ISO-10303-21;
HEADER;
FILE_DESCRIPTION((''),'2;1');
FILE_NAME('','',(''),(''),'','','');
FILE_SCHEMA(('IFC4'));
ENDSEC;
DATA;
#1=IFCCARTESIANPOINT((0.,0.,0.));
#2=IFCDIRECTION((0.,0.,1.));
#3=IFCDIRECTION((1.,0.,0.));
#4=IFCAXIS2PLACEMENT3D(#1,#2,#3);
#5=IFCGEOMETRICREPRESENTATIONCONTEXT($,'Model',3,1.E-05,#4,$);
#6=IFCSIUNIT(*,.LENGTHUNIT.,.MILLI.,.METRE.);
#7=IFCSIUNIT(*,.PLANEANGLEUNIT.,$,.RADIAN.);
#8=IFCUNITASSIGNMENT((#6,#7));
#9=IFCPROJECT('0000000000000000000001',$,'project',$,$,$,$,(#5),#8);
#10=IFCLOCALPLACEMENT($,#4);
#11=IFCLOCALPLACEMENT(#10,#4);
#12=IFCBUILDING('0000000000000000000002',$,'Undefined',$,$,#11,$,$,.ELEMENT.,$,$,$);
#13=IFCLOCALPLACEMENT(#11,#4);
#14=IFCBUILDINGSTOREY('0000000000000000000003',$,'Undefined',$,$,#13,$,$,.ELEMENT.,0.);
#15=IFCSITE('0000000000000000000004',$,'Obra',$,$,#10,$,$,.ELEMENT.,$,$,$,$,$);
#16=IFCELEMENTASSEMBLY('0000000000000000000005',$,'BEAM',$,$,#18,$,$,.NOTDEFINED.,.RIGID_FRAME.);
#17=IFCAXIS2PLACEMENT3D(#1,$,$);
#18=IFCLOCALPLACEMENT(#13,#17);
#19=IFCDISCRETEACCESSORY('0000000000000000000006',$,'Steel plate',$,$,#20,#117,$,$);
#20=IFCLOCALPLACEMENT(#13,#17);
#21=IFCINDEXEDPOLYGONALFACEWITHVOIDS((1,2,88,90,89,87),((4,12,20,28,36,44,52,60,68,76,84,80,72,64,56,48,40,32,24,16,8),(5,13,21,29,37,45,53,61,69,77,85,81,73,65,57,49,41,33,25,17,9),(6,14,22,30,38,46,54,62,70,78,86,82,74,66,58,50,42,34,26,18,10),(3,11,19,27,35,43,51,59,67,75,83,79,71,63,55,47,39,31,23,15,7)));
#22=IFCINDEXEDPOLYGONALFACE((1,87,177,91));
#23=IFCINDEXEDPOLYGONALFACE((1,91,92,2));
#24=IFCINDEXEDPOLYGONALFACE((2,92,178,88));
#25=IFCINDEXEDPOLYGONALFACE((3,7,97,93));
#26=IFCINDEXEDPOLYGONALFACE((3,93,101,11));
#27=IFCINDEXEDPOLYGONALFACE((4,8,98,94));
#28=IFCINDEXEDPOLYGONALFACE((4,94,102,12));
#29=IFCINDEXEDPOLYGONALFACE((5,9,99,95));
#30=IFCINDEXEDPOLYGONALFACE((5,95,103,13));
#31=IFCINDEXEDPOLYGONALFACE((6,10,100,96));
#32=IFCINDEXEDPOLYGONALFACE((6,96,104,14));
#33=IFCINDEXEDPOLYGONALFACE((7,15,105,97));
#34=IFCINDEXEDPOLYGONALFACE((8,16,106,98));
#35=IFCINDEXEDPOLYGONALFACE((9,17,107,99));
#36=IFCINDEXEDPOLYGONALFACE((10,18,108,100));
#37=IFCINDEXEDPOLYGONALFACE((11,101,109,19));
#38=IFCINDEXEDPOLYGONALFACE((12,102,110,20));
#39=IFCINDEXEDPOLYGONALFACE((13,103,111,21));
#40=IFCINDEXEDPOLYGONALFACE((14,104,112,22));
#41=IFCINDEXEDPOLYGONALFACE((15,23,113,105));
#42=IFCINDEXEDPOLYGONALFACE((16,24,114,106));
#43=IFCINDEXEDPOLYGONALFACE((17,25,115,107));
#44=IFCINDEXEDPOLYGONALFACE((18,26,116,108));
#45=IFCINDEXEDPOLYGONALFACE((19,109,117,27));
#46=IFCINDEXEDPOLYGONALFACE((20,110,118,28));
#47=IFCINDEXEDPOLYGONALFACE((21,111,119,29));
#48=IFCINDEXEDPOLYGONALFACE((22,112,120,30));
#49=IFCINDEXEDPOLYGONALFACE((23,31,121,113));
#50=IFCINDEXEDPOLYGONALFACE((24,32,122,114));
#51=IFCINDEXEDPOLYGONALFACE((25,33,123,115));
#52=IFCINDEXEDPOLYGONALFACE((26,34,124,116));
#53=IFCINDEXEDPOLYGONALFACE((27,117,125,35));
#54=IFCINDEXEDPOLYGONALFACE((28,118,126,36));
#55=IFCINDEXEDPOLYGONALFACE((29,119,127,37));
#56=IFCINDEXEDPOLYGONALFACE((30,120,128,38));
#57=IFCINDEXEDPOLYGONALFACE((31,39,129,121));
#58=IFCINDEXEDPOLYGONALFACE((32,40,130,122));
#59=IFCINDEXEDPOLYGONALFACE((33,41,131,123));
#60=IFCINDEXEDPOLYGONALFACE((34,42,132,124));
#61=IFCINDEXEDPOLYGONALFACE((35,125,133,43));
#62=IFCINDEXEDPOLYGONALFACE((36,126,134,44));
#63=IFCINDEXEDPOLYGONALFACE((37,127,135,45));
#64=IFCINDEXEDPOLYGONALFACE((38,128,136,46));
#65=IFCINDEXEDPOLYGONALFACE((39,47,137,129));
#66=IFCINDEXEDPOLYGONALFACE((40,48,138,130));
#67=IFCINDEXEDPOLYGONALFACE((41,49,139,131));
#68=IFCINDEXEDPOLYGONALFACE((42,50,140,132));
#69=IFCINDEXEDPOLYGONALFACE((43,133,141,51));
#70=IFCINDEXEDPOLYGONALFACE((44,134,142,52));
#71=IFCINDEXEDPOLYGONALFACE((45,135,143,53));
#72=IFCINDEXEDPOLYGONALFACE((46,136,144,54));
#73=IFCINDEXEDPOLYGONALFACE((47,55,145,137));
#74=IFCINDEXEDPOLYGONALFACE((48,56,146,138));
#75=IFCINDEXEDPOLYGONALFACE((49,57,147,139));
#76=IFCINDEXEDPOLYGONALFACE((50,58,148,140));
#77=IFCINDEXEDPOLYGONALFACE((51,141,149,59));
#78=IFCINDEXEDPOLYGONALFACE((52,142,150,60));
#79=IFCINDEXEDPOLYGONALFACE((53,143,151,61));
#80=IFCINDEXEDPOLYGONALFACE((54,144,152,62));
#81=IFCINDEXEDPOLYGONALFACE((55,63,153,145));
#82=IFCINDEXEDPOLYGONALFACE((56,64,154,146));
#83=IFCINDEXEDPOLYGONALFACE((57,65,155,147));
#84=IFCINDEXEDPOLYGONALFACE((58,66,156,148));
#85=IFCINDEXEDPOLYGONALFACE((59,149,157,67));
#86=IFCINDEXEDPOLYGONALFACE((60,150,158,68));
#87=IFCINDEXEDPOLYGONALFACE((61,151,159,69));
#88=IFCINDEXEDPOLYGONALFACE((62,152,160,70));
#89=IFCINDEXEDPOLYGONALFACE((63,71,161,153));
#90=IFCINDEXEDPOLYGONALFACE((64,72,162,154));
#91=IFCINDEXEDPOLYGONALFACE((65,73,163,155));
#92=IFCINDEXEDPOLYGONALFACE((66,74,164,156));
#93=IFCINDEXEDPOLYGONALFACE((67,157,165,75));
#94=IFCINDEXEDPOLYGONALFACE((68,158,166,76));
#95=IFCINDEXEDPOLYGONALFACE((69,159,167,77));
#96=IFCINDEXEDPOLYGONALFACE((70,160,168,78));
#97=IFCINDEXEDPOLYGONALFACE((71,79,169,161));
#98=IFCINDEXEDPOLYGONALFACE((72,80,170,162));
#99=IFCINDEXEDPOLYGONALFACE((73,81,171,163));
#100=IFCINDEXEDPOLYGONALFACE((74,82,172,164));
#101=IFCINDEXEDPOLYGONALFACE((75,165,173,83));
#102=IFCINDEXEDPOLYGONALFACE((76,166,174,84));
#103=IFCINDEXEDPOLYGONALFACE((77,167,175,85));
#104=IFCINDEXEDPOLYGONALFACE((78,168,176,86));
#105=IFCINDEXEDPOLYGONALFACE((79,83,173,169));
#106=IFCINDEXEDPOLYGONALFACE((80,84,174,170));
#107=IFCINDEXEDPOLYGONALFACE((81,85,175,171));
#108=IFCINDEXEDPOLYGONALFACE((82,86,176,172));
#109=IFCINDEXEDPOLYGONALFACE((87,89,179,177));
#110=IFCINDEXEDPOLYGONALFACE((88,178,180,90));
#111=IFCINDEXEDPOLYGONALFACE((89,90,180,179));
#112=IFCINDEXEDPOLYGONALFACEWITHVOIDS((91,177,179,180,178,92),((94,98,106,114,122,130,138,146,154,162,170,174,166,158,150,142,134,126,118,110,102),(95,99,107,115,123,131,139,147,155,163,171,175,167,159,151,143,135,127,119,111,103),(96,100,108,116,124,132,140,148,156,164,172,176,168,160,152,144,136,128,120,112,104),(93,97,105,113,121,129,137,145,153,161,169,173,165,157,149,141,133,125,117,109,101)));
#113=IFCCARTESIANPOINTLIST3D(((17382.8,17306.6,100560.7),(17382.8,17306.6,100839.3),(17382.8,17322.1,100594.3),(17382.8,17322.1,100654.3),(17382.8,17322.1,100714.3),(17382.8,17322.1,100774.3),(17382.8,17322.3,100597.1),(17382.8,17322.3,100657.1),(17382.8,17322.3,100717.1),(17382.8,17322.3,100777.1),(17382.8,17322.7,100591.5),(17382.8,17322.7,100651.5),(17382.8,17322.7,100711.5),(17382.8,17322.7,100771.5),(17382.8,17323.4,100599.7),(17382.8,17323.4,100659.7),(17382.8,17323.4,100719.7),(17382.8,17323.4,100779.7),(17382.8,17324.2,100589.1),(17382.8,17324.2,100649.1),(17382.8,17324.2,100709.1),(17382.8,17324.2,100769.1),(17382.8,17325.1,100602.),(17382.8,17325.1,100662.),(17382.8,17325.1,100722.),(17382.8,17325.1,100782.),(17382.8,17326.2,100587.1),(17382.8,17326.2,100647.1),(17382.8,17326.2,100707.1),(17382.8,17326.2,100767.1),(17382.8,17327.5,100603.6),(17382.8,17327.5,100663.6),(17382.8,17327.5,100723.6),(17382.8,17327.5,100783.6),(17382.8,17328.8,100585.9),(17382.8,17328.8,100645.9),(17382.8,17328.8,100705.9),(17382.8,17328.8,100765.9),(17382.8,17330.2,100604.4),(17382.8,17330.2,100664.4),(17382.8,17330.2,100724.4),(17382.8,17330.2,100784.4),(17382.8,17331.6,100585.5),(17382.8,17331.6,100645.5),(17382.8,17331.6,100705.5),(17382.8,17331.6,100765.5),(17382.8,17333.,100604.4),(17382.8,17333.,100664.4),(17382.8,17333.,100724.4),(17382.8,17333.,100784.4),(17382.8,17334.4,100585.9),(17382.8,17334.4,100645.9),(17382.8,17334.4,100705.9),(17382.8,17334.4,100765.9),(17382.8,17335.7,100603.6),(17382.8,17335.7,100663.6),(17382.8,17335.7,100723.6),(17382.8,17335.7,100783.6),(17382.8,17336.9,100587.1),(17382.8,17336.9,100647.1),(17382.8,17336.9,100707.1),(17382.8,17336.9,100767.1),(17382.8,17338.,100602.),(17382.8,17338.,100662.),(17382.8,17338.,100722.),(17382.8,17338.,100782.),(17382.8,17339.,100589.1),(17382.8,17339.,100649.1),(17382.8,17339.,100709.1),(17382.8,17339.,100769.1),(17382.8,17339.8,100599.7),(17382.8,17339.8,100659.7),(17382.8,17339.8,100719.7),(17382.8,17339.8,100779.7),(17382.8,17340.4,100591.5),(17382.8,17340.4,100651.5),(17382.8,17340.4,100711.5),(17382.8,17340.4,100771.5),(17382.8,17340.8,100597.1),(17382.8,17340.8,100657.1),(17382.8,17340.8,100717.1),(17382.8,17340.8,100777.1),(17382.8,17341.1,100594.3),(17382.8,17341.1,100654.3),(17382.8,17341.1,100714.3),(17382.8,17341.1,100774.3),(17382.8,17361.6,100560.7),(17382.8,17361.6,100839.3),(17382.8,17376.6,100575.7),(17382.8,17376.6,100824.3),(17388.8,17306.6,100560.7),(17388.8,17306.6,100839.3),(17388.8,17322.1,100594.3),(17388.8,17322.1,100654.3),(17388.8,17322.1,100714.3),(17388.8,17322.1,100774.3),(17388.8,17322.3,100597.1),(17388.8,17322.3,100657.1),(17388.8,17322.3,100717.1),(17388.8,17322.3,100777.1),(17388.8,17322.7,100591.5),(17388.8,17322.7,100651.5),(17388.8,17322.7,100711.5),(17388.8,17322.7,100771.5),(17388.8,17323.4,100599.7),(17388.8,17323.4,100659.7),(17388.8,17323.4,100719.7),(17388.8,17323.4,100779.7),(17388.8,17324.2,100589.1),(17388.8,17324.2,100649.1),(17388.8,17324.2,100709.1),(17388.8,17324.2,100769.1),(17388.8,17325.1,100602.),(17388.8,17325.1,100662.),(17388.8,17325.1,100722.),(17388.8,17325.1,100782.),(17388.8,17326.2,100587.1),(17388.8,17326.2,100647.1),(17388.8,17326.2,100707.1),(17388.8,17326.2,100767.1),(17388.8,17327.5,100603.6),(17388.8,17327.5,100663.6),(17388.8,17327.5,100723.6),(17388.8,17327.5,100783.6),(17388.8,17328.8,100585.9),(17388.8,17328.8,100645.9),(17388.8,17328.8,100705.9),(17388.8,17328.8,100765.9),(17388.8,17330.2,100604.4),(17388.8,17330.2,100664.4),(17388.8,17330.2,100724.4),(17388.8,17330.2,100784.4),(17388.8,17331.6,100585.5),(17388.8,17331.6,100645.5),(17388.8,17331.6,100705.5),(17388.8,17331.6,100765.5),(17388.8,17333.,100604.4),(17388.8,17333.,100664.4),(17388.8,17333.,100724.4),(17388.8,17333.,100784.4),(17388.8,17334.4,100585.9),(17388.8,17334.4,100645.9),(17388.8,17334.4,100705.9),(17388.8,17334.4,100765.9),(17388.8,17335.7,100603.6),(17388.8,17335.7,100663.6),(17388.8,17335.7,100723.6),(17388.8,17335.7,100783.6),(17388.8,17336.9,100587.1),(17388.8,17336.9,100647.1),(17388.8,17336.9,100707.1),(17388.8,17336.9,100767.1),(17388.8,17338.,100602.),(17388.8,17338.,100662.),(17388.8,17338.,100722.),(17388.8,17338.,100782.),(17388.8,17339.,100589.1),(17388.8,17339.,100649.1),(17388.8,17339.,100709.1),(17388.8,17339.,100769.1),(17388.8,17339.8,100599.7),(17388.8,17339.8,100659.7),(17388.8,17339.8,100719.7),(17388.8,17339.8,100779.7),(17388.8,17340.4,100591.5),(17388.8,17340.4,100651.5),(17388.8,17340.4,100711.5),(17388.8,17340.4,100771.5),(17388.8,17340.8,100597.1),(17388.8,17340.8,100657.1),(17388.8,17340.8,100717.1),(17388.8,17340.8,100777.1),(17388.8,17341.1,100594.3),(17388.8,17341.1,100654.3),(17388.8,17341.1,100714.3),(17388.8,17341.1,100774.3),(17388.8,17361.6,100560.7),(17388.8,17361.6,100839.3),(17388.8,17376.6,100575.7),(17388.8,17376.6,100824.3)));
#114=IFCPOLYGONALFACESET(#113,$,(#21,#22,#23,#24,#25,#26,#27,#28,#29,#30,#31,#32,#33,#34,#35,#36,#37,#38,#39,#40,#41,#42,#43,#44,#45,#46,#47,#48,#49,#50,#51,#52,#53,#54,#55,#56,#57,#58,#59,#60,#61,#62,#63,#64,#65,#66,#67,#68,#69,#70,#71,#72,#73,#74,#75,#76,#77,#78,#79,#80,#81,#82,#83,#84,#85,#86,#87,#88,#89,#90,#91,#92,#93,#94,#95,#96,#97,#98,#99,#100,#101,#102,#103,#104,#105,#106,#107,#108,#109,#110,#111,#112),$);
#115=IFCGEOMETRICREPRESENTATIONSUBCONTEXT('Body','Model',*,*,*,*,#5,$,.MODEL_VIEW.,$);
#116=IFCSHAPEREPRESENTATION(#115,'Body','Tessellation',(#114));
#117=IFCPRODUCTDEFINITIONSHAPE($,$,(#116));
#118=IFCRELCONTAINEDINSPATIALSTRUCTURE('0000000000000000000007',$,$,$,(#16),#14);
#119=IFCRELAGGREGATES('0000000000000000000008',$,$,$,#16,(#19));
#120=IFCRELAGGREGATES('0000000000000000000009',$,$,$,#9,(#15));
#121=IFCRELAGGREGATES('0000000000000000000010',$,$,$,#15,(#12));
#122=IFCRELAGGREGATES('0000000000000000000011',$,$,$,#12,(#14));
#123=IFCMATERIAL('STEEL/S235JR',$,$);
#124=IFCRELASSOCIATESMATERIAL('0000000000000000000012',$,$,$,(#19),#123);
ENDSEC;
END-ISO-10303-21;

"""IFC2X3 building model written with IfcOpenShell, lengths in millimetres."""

from ifc_helpers import new_model, si_unit, frame, origin_with_axes, origin_2d_with_axis, place, context, subcontext, project, spatial, polyline, circle, outline, extrude, source, transform, mapped, material, element, aggregate, save


model = new_model("IFC2X3")

# Units and contexts
model_context = context("Model", 3, precision=1e-05, world=origin_with_axes())
body_context = subcontext(model_context, "Body", "Model", "MODEL_VIEW")
ifc_project = project(units=[si_unit("LENGTHUNIT", "METRE", prefix="MILLI"), si_unit("PLANEANGLEUNIT", "RADIAN")], contexts=[model_context])

# Site, building, storey
site_placement = place(None, origin_with_axes())
site = spatial("IfcSite", under=ifc_project, at=site_placement, Name="Obra", CompositionType="ELEMENT")
building_placement = place(site_placement, origin_with_axes())
building = spatial("IfcBuilding", under=site, at=building_placement, Name="Undefined", CompositionType="ELEMENT")
storey_placement = place(building_placement, origin_with_axes())
storey = spatial("IfcBuildingStorey", under=building, at=storey_placement, Name="Undefined", CompositionType="ELEMENT", Elevation=0.0)

# Element assembly, discrete accessory, opening
assembly_1_placement = place(storey_placement, origin_with_axes())
assembly_1 = element("IfcElementAssembly", 1, at=assembly_1_placement, inside=storey, Name="BEAM", AssemblyPlace="NOTDEFINED", PredefinedType="RIGID_FRAME")
ifc_material_1 = material(Name="STEEL/S235JR")
shared_shape_1 = source(origin_with_axes(), body_context, "Body", "SweptSolid", [
    extrude(circle(Radius=9.5, at=origin_2d_with_axis()), frame((0.0, -9.8, 0.0), z_axis=(0.0, 1.0, 0.0), x_axis=(1.0, 0.0, 0.0)), (0.0, 0.0, 1.0), 6.2),
])
discrete_accessory_1_placement = place(assembly_1_placement, frame((17385.8, 17306.6, 100560.7), z_axis=(1.0, 0.0, 0.0), x_axis=(0.0, 1.0, 0.0)))
discrete_accessory_1 = element("IfcDiscreteAccessory", 2, at=discrete_accessory_1_placement, material=ifc_material_1, Name="Steel plate", context=body_context, shape_type="SweptSolid", body=[
    extrude(outline(polyline([(0.0, 0.0), (55.0, 0.0), (70.0, 15.0), (70.0, 263.6), (55.0, 278.6), (0.0, 278.6), (0.0, 0.0)])), frame((0.0, 0.0, -3.0), z_axis=(0.0, 0.0, 1.0), x_axis=(1.0, 0.0, 0.0)), (0.0, 0.0, 1.0), 6.0),
])
opening_1_placement = place(assembly_1_placement, frame((17392.6, 17366.6, 100850.0), z_axis=(0.0, -1.0, 0.0), x_axis=(0.0, 0.0, -1.0)))
element("IfcOpeningElement", 3, at=opening_1_placement, cuts=discrete_accessory_1, ObjectType="Opening", context=body_context, shape_type="MappedRepresentation", body=[
    mapped(shared_shape_1, transform((75.0, 0.0, 35.0))),
    mapped(shared_shape_1, transform((135.0, 0.0, 35.0))),
    mapped(shared_shape_1, transform((195.0, 0.0, 35.0))),
    mapped(shared_shape_1, transform((255.0, 0.0, 35.0))),
])

aggregate(assembly_1, [discrete_accessory_1])

save(model, "model.ifc")
